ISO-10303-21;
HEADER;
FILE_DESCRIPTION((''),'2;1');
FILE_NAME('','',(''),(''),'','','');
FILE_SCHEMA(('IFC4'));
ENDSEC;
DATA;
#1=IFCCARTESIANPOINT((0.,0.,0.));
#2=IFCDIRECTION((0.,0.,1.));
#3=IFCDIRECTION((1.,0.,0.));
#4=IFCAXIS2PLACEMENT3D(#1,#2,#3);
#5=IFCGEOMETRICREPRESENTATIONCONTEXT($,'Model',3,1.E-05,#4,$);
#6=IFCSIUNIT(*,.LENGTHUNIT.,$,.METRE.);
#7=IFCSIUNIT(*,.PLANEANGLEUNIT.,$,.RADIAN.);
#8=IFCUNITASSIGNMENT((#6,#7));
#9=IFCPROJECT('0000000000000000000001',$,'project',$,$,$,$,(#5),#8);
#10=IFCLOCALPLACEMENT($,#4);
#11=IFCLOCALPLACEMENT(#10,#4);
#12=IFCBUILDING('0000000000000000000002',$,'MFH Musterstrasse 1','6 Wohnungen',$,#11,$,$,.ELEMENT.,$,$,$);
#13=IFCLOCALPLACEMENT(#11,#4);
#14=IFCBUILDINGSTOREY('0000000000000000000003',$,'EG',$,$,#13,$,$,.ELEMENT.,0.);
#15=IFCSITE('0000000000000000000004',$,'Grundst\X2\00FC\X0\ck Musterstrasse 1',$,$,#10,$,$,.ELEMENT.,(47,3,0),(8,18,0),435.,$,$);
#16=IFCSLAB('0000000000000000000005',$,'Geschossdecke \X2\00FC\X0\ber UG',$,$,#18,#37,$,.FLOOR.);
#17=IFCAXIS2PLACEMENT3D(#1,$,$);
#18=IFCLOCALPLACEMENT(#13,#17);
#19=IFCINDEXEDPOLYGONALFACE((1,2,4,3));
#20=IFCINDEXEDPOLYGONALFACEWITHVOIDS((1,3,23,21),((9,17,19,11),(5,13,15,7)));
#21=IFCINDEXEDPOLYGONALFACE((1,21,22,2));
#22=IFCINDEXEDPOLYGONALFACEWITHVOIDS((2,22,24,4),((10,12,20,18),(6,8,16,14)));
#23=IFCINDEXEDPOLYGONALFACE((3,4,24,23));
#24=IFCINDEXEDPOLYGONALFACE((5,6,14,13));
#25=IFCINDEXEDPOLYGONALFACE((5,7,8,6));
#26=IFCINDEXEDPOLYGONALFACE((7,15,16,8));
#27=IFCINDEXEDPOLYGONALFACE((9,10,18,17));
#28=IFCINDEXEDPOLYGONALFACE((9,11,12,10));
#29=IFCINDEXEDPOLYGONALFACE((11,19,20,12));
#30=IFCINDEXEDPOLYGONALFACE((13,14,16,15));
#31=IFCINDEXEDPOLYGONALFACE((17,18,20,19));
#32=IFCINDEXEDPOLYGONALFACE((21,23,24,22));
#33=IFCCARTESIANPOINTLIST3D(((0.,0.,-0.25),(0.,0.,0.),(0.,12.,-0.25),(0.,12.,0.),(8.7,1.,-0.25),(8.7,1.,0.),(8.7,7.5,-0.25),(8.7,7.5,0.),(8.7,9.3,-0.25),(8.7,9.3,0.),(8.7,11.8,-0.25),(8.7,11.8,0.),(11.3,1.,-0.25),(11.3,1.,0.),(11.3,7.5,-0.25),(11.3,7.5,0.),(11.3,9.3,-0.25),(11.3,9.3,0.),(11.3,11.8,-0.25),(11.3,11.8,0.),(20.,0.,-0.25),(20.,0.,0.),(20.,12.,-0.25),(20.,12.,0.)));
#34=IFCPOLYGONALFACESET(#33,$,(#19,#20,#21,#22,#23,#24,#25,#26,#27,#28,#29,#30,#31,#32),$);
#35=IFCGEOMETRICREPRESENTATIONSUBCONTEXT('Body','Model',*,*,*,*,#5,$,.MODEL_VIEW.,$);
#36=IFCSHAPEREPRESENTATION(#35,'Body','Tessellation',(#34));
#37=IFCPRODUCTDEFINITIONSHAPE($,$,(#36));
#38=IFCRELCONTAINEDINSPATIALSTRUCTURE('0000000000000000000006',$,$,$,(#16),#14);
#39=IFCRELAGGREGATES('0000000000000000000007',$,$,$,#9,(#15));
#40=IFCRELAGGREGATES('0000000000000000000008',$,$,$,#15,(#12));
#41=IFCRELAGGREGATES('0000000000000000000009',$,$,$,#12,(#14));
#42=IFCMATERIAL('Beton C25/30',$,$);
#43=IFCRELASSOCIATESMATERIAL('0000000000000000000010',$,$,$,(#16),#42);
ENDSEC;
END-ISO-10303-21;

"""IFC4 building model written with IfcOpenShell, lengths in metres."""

from ifc_helpers import new_model, si_unit, frame, frame_2d, origin_with_axes, place, context, subcontext, project, spatial, rectangle, extrude, material, element, save


model = new_model("IFC4")

# Units and contexts
model_context = context("Model", 3, precision=1e-05, world=origin_with_axes())
body_context = subcontext(model_context, "Body", "Model", "MODEL_VIEW")
ifc_project = project(units=[si_unit("LENGTHUNIT", "METRE"), si_unit("PLANEANGLEUNIT", "RADIAN")], contexts=[model_context])

# Site, building, storey
site_placement = place(None, origin_with_axes())
site = spatial("IfcSite", under=ifc_project, at=site_placement, Name="Grundstück Musterstrasse 1", CompositionType="ELEMENT", RefLatitude=(47, 3, 0), RefLongitude=(8, 18, 0), RefElevation=435.0)
building_placement = place(site_placement, origin_with_axes())
building = spatial("IfcBuilding", under=site, at=building_placement, Name="MFH Musterstrasse 1", Description="6 Wohnungen", CompositionType="ELEMENT")
storey_placement = place(building_placement, origin_with_axes())
storey = spatial("IfcBuildingStorey", under=building, at=storey_placement, Name="EG", CompositionType="ELEMENT", Elevation=0.0)

# Slab, openings
ifc_material = material(Name="Beton C25/30")
slab_placement = place(storey_placement, origin_with_axes())
slab = element("IfcSlab", 1, at=slab_placement, inside=storey, material=ifc_material, Name="Geschossdecke über UG", PredefinedType="FLOOR", context=body_context, shape_type="SweptSolid", body=[
    extrude(rectangle(XDim=20.0, YDim=12.0, at=frame_2d((10.0, 6.0), x_axis=(1.0, 0.0))), frame((0.0, 0.0, -0.25), z_axis=(0.0, 0.0, 1.0), x_axis=(1.0, 0.0, 0.0)), (0.0, 0.0, 1.0), 0.25),
])
opening_1_placement = place(storey_placement, origin_with_axes())
element("IfcOpeningElement", 2, at=opening_1_placement, cuts=slab, PredefinedType="OPENING", context=body_context, shape_type="SweptSolid", body=[
    extrude(rectangle(XDim=2.6, YDim=6.5, at=frame_2d((1.3, 3.25), x_axis=(1.0, 0.0))), frame((8.7, 1.0, -0.26), z_axis=(0.0, 0.0, 1.0), x_axis=(1.0, 0.0, 0.0)), (0.0, 0.0, 1.0), 0.27),
])
opening_2_placement = place(storey_placement, origin_with_axes())
element("IfcOpeningElement", 3, at=opening_2_placement, cuts=slab, PredefinedType="OPENING", context=body_context, shape_type="SweptSolid", body=[
    extrude(rectangle(XDim=2.6, YDim=2.5, at=frame_2d((1.3, 1.25), x_axis=(1.0, 0.0))), frame((8.7, 9.3, -0.26), z_axis=(0.0, 0.0, 1.0), x_axis=(1.0, 0.0, 0.0)), (0.0, 0.0, 1.0), 0.27),
])

save(model, "model.ifc")
